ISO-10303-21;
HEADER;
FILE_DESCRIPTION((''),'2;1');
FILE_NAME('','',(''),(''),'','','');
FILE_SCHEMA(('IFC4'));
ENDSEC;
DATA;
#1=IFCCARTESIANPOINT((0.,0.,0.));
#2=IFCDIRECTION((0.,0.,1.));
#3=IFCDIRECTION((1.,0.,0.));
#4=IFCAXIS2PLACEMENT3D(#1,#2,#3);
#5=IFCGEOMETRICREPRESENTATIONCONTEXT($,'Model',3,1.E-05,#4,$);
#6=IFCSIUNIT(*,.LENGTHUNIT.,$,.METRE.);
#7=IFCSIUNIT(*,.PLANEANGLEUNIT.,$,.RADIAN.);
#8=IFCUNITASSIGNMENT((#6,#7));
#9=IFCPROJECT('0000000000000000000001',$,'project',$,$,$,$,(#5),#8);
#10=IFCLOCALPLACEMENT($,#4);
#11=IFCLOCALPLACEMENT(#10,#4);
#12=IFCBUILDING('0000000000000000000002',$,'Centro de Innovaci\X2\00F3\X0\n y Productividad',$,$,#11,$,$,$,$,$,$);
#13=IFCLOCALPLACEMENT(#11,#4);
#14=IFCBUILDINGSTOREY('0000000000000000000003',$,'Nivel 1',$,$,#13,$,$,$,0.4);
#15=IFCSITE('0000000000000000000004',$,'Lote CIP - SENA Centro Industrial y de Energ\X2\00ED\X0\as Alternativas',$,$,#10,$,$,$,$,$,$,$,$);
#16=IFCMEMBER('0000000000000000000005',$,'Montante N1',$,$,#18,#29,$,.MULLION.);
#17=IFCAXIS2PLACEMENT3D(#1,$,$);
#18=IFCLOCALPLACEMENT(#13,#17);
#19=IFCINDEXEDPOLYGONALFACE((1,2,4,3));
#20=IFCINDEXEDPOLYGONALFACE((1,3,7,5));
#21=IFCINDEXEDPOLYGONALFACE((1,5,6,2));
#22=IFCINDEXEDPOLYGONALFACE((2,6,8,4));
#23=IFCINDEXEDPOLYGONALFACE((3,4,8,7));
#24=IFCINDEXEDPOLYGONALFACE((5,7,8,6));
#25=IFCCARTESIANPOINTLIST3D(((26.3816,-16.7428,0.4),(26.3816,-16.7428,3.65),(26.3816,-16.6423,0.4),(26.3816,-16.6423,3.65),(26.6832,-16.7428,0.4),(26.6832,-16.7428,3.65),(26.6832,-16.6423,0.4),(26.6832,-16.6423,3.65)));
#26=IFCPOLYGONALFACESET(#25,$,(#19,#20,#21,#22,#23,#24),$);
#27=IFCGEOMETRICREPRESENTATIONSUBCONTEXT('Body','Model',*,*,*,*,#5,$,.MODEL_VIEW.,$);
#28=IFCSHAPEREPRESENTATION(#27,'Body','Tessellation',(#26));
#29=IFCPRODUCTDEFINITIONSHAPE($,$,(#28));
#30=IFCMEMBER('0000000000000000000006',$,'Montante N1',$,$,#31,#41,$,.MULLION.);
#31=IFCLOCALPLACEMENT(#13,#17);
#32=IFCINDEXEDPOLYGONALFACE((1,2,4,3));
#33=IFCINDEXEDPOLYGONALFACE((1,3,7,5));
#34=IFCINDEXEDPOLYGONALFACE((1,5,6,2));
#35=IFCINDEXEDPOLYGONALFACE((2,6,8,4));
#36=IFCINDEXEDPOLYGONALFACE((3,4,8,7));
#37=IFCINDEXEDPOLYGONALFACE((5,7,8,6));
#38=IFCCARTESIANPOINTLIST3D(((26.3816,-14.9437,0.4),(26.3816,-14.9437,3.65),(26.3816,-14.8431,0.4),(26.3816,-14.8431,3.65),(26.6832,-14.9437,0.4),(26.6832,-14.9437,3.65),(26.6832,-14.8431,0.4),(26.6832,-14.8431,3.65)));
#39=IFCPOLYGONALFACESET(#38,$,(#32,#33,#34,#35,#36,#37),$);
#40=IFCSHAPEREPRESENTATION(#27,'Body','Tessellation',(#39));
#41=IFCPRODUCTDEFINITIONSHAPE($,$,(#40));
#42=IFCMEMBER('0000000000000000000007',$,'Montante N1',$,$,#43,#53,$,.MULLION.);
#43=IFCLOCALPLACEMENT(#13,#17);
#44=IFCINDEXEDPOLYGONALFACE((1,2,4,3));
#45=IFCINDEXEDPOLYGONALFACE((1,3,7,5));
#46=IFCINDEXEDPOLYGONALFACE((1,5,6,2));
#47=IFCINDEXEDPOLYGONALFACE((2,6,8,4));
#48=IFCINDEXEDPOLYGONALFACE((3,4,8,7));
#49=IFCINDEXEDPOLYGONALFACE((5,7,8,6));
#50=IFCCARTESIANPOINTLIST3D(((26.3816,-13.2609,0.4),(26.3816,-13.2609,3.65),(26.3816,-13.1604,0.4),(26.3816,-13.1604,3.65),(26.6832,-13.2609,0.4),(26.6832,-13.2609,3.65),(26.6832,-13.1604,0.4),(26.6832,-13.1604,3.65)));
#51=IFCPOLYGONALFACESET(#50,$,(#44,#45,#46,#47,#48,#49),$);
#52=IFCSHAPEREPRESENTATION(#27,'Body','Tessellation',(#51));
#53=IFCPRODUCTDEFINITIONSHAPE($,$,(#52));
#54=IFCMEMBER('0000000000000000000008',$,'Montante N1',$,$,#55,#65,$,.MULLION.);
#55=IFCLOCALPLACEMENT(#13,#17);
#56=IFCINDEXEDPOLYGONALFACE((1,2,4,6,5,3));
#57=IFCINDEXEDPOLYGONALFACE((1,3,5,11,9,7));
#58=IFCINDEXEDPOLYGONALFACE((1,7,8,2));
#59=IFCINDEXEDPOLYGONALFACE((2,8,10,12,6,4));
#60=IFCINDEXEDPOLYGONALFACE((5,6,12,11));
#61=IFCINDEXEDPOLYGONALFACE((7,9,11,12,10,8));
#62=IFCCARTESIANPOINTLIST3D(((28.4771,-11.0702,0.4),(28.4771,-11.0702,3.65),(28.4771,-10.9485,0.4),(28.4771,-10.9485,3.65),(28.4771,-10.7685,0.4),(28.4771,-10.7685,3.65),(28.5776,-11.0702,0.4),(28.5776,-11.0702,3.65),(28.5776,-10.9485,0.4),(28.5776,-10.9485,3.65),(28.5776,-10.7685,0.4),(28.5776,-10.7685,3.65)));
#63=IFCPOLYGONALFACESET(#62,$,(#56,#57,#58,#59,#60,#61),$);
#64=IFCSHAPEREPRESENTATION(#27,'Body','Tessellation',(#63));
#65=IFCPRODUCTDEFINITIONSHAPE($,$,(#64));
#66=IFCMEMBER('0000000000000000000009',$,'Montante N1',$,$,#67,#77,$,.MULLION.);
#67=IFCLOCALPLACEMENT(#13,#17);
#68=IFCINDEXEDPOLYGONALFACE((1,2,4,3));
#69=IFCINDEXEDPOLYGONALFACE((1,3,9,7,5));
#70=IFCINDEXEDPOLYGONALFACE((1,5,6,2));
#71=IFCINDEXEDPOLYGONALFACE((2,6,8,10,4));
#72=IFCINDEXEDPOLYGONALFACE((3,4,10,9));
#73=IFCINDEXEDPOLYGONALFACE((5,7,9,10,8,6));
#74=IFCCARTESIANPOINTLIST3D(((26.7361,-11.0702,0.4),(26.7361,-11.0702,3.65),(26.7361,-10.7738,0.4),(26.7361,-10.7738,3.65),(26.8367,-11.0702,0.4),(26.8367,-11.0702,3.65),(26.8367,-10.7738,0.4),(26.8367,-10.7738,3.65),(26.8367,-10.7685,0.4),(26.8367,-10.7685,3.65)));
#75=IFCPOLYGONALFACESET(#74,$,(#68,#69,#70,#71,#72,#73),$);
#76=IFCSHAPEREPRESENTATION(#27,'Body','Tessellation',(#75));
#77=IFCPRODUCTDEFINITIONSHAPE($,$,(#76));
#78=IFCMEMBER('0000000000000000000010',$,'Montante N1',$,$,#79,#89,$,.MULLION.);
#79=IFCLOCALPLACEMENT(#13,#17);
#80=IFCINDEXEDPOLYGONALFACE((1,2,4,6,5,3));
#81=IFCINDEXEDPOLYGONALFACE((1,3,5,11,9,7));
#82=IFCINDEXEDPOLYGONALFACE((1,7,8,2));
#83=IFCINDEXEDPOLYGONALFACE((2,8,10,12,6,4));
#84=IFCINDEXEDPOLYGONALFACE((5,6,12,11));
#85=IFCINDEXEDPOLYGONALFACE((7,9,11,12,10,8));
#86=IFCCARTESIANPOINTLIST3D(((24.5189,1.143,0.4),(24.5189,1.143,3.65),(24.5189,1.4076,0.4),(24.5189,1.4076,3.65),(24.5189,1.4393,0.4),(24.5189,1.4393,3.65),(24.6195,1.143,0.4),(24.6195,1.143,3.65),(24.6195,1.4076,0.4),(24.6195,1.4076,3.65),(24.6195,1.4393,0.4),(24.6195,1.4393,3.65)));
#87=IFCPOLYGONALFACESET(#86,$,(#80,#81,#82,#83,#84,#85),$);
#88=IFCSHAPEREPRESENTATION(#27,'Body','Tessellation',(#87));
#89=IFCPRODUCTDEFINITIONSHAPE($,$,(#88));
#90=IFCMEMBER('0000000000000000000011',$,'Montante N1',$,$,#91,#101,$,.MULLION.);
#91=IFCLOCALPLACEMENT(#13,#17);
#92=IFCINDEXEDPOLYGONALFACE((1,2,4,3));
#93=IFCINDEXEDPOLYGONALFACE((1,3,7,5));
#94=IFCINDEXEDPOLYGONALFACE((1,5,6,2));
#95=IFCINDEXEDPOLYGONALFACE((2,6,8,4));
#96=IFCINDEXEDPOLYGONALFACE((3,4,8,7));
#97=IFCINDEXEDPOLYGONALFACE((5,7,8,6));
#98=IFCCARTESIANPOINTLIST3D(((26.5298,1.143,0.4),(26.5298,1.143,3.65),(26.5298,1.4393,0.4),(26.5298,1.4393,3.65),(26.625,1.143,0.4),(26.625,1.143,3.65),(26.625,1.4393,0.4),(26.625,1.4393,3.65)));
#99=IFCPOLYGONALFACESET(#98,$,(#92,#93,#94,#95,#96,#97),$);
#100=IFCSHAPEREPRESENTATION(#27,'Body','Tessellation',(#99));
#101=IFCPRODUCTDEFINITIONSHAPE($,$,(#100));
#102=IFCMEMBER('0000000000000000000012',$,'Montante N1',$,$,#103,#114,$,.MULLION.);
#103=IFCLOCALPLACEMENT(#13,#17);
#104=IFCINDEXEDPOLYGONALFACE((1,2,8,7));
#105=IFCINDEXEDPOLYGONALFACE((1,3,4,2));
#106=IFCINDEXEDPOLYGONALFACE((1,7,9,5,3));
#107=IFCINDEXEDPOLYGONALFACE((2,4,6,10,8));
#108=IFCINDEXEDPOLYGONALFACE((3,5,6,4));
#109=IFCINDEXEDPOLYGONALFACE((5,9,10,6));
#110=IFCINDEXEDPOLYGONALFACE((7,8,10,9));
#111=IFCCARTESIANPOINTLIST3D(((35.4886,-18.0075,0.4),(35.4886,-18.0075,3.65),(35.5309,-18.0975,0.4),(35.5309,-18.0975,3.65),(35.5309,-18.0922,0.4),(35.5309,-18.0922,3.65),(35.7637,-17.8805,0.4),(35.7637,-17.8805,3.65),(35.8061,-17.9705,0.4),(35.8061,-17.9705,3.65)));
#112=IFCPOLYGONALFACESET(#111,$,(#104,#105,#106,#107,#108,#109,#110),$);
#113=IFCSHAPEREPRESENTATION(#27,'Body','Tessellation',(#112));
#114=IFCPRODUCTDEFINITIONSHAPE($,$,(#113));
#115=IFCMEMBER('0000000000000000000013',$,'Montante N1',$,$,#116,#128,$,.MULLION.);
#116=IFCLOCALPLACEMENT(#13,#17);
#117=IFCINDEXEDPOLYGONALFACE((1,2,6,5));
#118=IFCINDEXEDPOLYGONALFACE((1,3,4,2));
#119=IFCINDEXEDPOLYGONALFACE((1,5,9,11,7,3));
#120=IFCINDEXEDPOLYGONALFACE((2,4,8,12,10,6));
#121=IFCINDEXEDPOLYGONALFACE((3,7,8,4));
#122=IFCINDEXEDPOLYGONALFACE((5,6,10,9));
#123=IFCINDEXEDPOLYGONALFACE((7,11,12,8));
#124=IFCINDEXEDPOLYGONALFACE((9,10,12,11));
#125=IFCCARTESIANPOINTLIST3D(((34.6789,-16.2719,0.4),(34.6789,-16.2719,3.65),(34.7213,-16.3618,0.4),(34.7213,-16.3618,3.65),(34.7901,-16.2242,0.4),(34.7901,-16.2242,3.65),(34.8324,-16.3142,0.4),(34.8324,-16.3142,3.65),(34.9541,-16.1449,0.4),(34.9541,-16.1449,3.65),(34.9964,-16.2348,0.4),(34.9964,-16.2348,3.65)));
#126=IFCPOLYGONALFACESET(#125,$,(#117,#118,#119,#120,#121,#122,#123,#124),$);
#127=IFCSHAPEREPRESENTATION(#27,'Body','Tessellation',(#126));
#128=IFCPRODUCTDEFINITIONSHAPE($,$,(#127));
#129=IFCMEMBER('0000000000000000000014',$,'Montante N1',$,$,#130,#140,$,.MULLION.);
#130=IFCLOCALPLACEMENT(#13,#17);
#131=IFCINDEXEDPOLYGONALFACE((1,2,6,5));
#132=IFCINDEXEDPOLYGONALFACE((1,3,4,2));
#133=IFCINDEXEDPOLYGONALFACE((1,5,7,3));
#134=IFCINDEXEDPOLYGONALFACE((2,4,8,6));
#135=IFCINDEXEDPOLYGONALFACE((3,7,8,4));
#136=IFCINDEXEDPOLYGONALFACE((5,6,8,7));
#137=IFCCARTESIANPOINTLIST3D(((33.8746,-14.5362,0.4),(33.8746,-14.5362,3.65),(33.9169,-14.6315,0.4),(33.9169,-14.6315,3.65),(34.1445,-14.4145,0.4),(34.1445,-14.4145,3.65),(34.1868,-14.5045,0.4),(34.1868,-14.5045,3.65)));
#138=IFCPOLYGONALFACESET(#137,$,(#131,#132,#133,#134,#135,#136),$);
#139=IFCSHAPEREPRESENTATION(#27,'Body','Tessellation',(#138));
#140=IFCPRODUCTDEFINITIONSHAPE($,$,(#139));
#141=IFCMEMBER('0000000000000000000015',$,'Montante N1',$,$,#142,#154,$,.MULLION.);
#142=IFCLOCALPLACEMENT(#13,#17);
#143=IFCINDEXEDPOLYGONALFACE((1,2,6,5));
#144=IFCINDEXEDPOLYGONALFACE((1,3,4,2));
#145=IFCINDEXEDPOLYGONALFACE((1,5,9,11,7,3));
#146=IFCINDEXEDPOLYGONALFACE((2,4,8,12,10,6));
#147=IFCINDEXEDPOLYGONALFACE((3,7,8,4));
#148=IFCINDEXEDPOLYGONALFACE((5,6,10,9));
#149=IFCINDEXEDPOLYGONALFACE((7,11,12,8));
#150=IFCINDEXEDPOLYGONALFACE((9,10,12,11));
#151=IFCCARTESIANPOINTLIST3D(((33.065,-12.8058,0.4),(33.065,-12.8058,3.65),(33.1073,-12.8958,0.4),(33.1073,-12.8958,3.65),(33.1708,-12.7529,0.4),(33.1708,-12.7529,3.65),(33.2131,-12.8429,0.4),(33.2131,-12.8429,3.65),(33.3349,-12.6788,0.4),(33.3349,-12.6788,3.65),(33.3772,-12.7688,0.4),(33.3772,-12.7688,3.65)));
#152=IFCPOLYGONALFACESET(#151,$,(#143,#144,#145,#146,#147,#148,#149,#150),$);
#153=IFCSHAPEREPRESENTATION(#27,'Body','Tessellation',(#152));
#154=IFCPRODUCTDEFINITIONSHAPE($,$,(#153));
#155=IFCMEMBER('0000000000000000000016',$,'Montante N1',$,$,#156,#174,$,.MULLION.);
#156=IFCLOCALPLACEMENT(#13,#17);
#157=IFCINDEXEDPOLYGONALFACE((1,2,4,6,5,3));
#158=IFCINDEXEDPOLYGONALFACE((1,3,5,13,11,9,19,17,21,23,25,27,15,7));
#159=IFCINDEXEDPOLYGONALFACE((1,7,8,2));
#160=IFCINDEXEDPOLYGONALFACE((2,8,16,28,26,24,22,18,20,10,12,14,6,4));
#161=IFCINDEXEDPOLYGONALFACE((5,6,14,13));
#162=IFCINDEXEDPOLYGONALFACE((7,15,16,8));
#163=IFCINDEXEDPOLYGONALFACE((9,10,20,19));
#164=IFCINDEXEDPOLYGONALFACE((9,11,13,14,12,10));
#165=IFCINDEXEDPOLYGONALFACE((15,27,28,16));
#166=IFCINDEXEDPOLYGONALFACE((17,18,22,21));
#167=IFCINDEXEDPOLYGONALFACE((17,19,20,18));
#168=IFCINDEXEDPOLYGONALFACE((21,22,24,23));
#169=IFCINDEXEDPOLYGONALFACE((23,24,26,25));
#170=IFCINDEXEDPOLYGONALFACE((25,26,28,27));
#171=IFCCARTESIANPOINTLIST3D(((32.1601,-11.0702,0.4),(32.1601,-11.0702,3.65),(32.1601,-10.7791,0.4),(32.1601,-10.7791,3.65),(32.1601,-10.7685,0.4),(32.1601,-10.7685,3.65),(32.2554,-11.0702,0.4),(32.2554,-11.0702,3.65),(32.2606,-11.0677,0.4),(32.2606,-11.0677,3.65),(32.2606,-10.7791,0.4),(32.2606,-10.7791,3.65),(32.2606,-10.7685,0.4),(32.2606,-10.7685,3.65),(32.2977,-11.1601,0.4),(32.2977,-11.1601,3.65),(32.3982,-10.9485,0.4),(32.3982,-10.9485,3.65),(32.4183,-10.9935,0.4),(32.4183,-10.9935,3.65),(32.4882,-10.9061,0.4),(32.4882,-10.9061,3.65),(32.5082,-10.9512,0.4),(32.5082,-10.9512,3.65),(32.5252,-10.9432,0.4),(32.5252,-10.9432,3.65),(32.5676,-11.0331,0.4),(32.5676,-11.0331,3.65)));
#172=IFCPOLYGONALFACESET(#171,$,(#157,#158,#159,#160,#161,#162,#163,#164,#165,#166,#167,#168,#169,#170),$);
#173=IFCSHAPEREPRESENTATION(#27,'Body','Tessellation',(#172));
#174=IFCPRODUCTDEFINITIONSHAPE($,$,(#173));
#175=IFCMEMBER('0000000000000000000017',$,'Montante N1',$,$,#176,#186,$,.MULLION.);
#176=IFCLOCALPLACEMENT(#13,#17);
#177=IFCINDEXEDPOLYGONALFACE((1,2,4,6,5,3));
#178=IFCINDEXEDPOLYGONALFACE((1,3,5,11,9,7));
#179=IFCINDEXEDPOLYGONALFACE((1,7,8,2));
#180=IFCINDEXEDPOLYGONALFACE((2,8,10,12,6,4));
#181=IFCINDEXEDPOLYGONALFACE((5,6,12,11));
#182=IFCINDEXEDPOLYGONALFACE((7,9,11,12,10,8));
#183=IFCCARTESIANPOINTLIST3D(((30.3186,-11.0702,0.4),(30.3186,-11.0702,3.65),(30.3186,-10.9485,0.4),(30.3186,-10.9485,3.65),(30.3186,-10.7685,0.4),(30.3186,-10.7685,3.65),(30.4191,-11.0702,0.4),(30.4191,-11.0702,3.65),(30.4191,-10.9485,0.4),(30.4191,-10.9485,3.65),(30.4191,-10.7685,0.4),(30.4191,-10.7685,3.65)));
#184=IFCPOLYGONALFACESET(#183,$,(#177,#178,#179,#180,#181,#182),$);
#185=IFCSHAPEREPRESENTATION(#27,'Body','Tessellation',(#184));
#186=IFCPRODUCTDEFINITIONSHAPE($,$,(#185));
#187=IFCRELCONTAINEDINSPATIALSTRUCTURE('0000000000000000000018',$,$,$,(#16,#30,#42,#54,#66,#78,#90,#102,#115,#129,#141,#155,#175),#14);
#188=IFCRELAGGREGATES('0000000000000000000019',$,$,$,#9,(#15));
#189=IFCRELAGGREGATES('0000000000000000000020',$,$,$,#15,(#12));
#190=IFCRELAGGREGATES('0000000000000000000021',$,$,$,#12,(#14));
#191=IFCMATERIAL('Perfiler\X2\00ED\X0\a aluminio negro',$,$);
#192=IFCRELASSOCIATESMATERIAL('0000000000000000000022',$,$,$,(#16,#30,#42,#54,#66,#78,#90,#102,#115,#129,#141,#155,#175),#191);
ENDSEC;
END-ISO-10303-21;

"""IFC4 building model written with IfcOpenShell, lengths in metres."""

from ifc_helpers import new_model, si_unit, frame, origin_with_axes, place, context, subcontext, project, spatial, polyline, outline, extrude, material, element, save


model = new_model("IFC4")

# Units and contexts
model_context = context("Model", 3, precision=1e-05, world=origin_with_axes())
body_context = subcontext(model_context, "Body", "Model", "MODEL_VIEW")
ifc_project = project(units=[si_unit("LENGTHUNIT", "METRE"), si_unit("PLANEANGLEUNIT", "RADIAN")], contexts=[model_context])

# Site, building, storey
site_placement = place(None, origin_with_axes())
site = spatial("IfcSite", under=ifc_project, at=site_placement, Name="Lote CIP - SENA Centro Industrial y de Energías Alternativas")
building_placement = place(site_placement, origin_with_axes())
building = spatial("IfcBuilding", under=site, at=building_placement, Name="Centro de Innovación y Productividad")
storey_placement = place(building_placement, origin_with_axes())
storey = spatial("IfcBuildingStorey", under=building, at=storey_placement, Name="Nivel 1", Elevation=0.4)

# Members
ifc_material = material(Name="Perfilería aluminio negro")
member_1_placement = place(storey_placement, origin_with_axes())
element("IfcMember", 1, at=member_1_placement, inside=storey, material=ifc_material, Name="Montante N1", PredefinedType="MULLION", context=body_context, shape_type="SweptSolid", body=[
    extrude(outline(polyline([(26.6832, -16.7428), (26.3816, -16.7428), (26.3816, -16.6423), (26.6832, -16.6423), (26.6832, -16.7428)])), frame((0.0, 0.0, 0.4)), (0.0, 0.0, 1.0), 3.25),
])
member_2_placement = place(storey_placement, origin_with_axes())
element("IfcMember", 2, at=member_2_placement, inside=storey, material=ifc_material, Name="Montante N1", PredefinedType="MULLION", context=body_context, shape_type="SweptSolid", body=[
    extrude(outline(polyline([(26.6832, -14.8431), (26.6832, -14.9437), (26.3816, -14.9437), (26.3816, -14.8431), (26.6832, -14.8431)])), frame((0.0, 0.0, 0.4)), (0.0, 0.0, 1.0), 3.25),
])
member_3_placement = place(storey_placement, origin_with_axes())
element("IfcMember", 3, at=member_3_placement, inside=storey, material=ifc_material, Name="Montante N1", PredefinedType="MULLION", context=body_context, shape_type="SweptSolid", body=[
    extrude(outline(polyline([(26.6832, -13.1604), (26.6832, -13.2609), (26.3816, -13.2609), (26.3816, -13.1604), (26.6832, -13.1604)])), frame((0.0, 0.0, 0.4)), (0.0, 0.0, 1.0), 3.25),
])
member_4_placement = place(storey_placement, origin_with_axes())
element("IfcMember", 4, at=member_4_placement, inside=storey, material=ifc_material, Name="Montante N1", PredefinedType="MULLION", context=body_context, shape_type="SweptSolid", body=[
    extrude(outline(polyline([(28.4771, -11.0702), (28.4771, -10.9485), (28.4771, -10.7685), (28.5776, -10.7685), (28.5776, -10.9485), (28.5776, -11.0702), (28.4771, -11.0702)])), frame((0.0, 0.0, 0.4)), (0.0, 0.0, 1.0), 3.25),
])
member_5_placement = place(storey_placement, origin_with_axes())
element("IfcMember", 5, at=member_5_placement, inside=storey, material=ifc_material, Name="Montante N1", PredefinedType="MULLION", context=body_context, shape_type="SweptSolid", body=[
    extrude(outline(polyline([(26.8367, -10.7738), (26.8367, -11.0702), (26.7361, -11.0702), (26.7361, -10.7738), (26.8367, -10.7685), (26.8367, -10.7738)])), frame((0.0, 0.0, 0.4)), (0.0, 0.0, 1.0), 3.25),
])
member_6_placement = place(storey_placement, origin_with_axes())
element("IfcMember", 6, at=member_6_placement, inside=storey, material=ifc_material, Name="Montante N1", PredefinedType="MULLION", context=body_context, shape_type="SweptSolid", body=[
    extrude(outline(polyline([(24.5189, 1.143), (24.5189, 1.4076), (24.5189, 1.4393), (24.6195, 1.4393), (24.6195, 1.4076), (24.6195, 1.143), (24.5189, 1.143)])), frame((0.0, 0.0, 0.4)), (0.0, 0.0, 1.0), 3.25),
])
member_7_placement = place(storey_placement, origin_with_axes())
element("IfcMember", 7, at=member_7_placement, inside=storey, material=ifc_material, Name="Montante N1", PredefinedType="MULLION", context=body_context, shape_type="SweptSolid", body=[
    extrude(outline(polyline([(26.5298, 1.143), (26.5298, 1.4393), (26.625, 1.4393), (26.625, 1.143), (26.5298, 1.143)])), frame((0.0, 0.0, 0.4)), (0.0, 0.0, 1.0), 3.25),
])
member_8_placement = place(storey_placement, origin_with_axes())
element("IfcMember", 8, at=member_8_placement, inside=storey, material=ifc_material, Name="Montante N1", PredefinedType="MULLION", context=body_context, shape_type="SweptSolid", body=[
    extrude(outline(polyline([(35.8061, -17.9705), (35.5309, -18.0922), (35.5309, -18.0975), (35.4886, -18.0075), (35.7637, -17.8805), (35.8061, -17.9705)])), frame((0.0, 0.0, 0.4)), (0.0, 0.0, 1.0), 3.25),
])
member_9_placement = place(storey_placement, origin_with_axes())
element("IfcMember", 9, at=member_9_placement, inside=storey, material=ifc_material, Name="Montante N1", PredefinedType="MULLION", context=body_context, shape_type="SweptSolid", body=[
    extrude(outline(polyline([(34.6789, -16.2719), (34.7901, -16.2242), (34.9541, -16.1449), (34.9964, -16.2348), (34.8324, -16.3142), (34.7213, -16.3618), (34.6789, -16.2719)])), frame((0.0, 0.0, 0.4)), (0.0, 0.0, 1.0), 3.25),
])
member_10_placement = place(storey_placement, origin_with_axes())
element("IfcMember", 10, at=member_10_placement, inside=storey, material=ifc_material, Name="Montante N1", PredefinedType="MULLION", context=body_context, shape_type="SweptSolid", body=[
    extrude(outline(polyline([(34.1868, -14.5045), (33.9169, -14.6315), (33.8746, -14.5362), (34.1445, -14.4145), (34.1868, -14.5045)])), frame((0.0, 0.0, 0.4)), (0.0, 0.0, 1.0), 3.25),
])
member_11_placement = place(storey_placement, origin_with_axes())
element("IfcMember", 11, at=member_11_placement, inside=storey, material=ifc_material, Name="Montante N1", PredefinedType="MULLION", context=body_context, shape_type="SweptSolid", body=[
    extrude(outline(polyline([(33.3349, -12.6788), (33.3772, -12.7688), (33.2131, -12.8429), (33.1073, -12.8958), (33.065, -12.8058), (33.1708, -12.7529), (33.3349, -12.6788)])), frame((0.0, 0.0, 0.4)), (0.0, 0.0, 1.0), 3.25),
])
member_12_placement = place(storey_placement, origin_with_axes())
element("IfcMember", 12, at=member_12_placement, inside=storey, material=ifc_material, Name="Montante N1", PredefinedType="MULLION", context=body_context, shape_type="SweptSolid", body=[
    extrude(outline(polyline([(32.2554, -11.0702), (32.1601, -11.0702), (32.1601, -10.7791), (32.1601, -10.7685), (32.2606, -10.7685), (32.2606, -10.7791), (32.2606, -11.0677), (32.4183, -10.9935), (32.3982, -10.9485), (32.4882, -10.9061), (32.5082, -10.9512), (32.5252, -10.9432), (32.5676, -11.0331), (32.2977, -11.1601), (32.2554, -11.0702)])), frame((0.0, 0.0, 0.4)), (0.0, 0.0, 1.0), 3.25),
])
member_13_placement = place(storey_placement, origin_with_axes())
element("IfcMember", 13, at=member_13_placement, inside=storey, material=ifc_material, Name="Montante N1", PredefinedType="MULLION", context=body_context, shape_type="SweptSolid", body=[
    extrude(outline(polyline([(30.4191, -11.0702), (30.3186, -11.0702), (30.3186, -10.9485), (30.3186, -10.7685), (30.4191, -10.7685), (30.4191, -10.9485), (30.4191, -11.0702)])), frame((0.0, 0.0, 0.4)), (0.0, 0.0, 1.0), 3.25),
])

save(model, "model.ifc")
